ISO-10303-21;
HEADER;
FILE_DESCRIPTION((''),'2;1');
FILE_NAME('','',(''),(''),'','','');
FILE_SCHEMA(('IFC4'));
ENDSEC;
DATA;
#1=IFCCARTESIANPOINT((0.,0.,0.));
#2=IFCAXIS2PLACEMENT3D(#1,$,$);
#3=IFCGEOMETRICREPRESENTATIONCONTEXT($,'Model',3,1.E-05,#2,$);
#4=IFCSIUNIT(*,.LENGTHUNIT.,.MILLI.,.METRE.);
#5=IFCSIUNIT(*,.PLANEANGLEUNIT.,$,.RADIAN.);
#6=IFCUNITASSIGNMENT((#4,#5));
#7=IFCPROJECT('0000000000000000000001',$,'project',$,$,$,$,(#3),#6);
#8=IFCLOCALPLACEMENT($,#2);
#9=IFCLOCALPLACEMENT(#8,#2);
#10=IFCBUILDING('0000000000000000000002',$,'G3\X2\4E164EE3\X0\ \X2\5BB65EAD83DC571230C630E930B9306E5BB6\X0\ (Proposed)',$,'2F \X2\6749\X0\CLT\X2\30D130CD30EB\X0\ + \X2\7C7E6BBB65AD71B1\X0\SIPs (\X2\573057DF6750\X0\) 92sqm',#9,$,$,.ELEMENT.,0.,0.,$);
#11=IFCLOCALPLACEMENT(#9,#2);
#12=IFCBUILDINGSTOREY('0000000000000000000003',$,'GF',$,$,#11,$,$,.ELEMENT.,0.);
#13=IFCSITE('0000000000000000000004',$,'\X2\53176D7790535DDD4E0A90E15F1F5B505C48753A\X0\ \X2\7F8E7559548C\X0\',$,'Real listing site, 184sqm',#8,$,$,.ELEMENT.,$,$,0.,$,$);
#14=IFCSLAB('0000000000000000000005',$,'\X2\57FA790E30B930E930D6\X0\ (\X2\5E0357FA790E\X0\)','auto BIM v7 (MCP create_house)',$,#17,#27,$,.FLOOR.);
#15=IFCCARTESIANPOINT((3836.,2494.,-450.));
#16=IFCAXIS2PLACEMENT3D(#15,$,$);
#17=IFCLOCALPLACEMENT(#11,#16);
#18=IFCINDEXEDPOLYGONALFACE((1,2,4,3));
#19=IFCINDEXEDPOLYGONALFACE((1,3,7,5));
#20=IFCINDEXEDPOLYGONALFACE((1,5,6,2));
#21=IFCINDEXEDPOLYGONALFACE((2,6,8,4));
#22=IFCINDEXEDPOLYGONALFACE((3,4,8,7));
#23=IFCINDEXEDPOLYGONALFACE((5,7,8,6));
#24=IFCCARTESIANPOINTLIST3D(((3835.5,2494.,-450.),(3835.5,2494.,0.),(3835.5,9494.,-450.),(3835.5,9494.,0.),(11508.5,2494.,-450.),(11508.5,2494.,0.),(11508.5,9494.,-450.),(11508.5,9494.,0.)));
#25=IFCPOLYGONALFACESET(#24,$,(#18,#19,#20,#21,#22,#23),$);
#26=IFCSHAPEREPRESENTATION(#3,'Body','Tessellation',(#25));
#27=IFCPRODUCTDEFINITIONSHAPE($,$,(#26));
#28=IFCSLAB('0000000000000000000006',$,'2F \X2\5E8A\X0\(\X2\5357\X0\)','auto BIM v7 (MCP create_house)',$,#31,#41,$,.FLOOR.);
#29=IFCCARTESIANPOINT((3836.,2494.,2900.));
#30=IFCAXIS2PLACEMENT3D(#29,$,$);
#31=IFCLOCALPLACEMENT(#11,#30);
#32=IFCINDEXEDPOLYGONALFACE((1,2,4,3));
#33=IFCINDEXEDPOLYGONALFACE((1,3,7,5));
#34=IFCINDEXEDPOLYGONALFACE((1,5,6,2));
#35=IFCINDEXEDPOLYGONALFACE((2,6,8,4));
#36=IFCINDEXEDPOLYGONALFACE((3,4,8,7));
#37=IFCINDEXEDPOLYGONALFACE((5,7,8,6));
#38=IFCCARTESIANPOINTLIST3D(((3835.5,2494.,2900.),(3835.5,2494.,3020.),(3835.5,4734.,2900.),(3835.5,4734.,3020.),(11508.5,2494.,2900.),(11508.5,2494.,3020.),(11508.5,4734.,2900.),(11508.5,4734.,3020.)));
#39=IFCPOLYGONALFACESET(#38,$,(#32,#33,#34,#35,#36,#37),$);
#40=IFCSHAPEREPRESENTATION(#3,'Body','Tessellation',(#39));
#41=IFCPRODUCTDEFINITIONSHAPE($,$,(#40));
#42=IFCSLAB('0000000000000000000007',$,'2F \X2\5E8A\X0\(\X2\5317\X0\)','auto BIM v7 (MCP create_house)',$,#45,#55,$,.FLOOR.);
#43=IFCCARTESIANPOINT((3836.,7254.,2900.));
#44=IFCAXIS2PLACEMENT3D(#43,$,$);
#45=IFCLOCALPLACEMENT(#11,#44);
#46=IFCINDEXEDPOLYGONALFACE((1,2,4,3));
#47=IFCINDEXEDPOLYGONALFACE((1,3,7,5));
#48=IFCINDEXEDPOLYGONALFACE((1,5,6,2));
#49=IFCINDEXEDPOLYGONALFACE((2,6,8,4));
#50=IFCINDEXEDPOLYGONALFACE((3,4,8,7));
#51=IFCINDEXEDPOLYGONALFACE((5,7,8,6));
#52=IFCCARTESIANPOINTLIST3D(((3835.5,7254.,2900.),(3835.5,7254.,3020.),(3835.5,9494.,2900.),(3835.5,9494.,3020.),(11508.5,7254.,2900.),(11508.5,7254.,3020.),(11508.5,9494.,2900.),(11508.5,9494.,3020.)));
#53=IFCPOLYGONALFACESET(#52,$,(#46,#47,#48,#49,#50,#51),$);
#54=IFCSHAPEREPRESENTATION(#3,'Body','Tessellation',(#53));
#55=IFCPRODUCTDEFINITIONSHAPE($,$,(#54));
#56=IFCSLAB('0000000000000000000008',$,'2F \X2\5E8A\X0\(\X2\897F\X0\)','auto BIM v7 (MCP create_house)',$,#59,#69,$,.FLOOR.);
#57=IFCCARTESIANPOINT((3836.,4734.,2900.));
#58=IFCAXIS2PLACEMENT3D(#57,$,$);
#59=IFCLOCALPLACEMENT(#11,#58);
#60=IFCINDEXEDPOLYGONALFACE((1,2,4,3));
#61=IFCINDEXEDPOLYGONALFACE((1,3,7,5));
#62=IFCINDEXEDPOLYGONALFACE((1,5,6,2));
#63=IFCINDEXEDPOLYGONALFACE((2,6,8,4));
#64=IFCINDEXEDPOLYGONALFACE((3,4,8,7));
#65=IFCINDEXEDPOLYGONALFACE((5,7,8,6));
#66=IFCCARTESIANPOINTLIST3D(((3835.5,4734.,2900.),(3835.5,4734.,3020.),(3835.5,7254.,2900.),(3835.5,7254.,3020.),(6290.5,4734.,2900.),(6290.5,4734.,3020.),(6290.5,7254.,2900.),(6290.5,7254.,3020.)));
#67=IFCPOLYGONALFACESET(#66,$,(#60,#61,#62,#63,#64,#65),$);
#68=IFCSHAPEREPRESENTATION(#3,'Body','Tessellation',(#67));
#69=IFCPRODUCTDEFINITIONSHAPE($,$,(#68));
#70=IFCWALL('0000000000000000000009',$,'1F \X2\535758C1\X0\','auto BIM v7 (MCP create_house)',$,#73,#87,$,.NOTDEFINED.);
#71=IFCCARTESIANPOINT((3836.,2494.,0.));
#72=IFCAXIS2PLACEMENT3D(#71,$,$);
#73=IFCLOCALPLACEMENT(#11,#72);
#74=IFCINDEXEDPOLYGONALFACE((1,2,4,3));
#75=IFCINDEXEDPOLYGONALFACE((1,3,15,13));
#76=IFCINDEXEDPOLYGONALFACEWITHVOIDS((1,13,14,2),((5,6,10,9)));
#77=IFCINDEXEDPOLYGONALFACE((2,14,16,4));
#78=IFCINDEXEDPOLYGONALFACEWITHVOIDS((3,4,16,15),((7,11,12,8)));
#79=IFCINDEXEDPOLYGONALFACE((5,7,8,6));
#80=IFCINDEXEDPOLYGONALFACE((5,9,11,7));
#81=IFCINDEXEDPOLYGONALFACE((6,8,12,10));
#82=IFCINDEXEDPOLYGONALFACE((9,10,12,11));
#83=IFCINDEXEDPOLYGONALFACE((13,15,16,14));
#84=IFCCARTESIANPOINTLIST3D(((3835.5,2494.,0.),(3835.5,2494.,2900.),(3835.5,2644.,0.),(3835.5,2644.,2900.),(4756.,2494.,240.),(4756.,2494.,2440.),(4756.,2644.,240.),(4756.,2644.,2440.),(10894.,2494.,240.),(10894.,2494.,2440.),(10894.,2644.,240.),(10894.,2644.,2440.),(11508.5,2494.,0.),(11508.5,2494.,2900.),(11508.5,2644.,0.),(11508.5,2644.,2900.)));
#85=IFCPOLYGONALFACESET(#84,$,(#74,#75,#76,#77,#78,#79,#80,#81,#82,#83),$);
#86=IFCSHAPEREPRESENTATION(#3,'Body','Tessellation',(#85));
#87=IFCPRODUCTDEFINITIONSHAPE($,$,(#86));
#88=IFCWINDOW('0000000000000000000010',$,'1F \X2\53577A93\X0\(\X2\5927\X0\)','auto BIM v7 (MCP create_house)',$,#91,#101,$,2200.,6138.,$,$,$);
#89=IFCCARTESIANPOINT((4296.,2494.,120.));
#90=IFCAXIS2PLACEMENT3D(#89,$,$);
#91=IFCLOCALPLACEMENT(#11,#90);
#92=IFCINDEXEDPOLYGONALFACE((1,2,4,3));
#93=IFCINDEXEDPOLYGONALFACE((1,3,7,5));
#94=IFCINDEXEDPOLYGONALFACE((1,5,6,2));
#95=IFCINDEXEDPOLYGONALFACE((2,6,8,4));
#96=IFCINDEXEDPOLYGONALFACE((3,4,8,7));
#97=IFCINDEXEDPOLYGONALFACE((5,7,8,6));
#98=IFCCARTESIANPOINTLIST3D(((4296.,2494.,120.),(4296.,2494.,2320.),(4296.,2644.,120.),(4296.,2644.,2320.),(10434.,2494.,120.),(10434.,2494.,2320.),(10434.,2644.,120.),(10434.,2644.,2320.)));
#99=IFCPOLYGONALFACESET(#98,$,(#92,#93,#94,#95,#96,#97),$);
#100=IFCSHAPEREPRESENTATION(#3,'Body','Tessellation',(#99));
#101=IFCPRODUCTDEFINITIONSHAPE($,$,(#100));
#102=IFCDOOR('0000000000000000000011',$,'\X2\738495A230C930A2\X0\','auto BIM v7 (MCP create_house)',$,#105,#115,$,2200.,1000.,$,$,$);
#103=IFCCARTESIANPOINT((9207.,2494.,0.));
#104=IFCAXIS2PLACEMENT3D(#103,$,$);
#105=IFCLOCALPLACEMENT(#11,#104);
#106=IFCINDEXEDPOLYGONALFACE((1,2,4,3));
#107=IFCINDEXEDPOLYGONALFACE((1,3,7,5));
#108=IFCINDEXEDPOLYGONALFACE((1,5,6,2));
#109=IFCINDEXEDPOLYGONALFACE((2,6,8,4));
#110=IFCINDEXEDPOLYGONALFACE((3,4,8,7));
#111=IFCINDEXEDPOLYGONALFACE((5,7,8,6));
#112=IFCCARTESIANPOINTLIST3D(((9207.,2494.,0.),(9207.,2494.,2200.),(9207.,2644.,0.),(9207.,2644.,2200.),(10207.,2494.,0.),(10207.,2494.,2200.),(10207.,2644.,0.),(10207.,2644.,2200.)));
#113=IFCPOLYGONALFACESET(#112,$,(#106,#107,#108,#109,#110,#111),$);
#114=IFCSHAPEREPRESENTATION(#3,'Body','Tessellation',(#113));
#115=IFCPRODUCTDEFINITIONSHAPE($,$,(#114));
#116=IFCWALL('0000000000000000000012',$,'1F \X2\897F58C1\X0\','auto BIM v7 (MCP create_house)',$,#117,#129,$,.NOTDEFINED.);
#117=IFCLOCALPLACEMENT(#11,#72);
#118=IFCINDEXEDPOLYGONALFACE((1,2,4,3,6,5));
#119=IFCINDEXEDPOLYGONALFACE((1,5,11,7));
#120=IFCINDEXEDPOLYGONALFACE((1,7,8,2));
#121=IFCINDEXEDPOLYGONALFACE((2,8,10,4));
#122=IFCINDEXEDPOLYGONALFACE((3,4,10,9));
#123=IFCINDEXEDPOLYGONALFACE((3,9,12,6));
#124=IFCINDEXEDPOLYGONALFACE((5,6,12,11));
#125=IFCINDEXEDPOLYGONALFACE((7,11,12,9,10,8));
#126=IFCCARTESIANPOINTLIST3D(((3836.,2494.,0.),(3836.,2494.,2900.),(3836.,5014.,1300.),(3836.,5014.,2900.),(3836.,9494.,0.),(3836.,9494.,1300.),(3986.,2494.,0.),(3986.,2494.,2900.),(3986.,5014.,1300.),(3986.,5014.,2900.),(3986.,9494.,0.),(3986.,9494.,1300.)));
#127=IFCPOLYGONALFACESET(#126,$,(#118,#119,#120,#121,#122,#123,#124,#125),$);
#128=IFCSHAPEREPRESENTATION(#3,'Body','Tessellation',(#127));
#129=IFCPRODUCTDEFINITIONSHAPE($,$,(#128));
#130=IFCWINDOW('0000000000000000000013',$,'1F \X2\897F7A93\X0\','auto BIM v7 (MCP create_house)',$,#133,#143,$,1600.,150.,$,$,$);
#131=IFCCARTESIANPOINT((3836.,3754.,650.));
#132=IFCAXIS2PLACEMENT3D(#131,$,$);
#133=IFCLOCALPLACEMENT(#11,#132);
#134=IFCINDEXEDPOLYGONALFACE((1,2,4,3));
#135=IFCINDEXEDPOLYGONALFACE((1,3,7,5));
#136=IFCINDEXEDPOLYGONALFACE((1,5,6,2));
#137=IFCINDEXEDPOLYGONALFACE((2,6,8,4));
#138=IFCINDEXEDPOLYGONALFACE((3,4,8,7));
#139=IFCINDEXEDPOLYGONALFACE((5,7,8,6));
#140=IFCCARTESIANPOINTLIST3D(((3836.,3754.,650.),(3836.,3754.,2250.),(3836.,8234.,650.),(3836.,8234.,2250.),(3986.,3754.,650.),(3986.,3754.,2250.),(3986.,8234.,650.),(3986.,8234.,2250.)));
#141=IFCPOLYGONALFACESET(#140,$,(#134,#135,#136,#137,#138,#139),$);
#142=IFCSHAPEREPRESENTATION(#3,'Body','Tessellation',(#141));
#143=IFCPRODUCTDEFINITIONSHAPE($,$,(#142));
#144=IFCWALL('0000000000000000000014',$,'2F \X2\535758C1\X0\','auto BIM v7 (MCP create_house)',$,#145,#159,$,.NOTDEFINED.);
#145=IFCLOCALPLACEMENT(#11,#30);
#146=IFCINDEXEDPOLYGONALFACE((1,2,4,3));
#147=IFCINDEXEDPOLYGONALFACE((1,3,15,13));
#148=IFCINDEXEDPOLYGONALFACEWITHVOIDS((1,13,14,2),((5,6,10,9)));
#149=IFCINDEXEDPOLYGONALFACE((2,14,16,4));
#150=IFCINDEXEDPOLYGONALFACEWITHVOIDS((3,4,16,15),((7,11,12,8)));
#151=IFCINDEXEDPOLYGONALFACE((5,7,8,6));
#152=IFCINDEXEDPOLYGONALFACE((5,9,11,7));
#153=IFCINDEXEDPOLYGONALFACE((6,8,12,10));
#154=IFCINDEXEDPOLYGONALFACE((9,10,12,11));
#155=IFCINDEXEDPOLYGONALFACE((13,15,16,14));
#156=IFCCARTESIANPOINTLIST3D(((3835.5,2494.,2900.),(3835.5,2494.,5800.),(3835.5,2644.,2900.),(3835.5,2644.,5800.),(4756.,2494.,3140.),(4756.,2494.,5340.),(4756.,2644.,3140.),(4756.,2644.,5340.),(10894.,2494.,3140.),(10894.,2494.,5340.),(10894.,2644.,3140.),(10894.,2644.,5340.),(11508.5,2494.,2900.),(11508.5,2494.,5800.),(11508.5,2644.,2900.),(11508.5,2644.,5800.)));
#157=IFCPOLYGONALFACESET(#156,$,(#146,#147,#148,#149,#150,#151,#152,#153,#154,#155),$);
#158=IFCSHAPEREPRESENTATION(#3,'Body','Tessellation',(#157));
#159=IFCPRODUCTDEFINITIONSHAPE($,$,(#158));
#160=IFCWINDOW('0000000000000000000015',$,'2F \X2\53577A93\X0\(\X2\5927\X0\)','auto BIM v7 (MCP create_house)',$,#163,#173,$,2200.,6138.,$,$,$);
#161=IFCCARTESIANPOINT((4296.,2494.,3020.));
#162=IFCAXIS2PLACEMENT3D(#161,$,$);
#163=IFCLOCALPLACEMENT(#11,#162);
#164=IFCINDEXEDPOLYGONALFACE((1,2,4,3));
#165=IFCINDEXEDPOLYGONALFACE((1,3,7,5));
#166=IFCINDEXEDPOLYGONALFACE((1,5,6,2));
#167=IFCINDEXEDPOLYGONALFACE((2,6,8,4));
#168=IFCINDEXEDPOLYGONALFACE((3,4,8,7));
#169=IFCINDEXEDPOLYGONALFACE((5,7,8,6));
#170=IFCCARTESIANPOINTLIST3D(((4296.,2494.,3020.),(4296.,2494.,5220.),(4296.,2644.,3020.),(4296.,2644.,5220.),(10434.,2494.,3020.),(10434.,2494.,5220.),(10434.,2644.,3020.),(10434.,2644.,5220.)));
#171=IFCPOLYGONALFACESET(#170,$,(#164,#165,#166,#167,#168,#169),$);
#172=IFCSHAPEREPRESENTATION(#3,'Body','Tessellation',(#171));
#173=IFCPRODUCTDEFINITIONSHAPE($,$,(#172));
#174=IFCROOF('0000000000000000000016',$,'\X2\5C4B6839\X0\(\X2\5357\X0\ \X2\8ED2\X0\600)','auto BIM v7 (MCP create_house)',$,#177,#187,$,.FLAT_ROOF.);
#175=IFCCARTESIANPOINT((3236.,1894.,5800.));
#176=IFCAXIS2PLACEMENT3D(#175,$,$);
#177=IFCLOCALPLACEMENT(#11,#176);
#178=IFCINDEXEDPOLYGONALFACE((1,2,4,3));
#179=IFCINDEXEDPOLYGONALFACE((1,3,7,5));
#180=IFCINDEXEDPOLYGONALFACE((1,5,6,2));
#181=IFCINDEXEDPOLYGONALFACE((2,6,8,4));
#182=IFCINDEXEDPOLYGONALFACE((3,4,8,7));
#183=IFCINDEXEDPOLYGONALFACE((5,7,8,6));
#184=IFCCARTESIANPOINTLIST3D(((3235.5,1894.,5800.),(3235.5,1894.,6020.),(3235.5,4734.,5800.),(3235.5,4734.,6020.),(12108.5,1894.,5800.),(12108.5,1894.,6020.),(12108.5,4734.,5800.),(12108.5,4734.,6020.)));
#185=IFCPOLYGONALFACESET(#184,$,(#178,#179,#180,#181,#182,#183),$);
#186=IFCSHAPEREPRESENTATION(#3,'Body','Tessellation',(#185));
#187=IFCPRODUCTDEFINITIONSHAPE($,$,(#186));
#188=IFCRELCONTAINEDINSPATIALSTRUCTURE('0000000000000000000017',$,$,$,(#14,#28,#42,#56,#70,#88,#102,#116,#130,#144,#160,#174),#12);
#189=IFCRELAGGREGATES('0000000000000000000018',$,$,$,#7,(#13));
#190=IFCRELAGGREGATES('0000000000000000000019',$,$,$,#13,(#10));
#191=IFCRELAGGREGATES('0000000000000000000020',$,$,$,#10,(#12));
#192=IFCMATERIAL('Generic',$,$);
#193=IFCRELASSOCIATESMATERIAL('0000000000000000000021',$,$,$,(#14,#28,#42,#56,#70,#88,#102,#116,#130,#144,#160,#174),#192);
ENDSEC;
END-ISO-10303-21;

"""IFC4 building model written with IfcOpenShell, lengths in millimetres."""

from ifc_helpers import new_model, si_unit, frame, frame_2d, origin, place, context, project, spatial, rectangle, extrude, material, element, fill, save


model = new_model("IFC4")

# Units and contexts
model_context = context("Model", 3, precision=1e-05, world=origin())
ifc_project = project(units=[si_unit("LENGTHUNIT", "METRE", prefix="MILLI"), si_unit("PLANEANGLEUNIT", "RADIAN")], contexts=[model_context])

# Site, building, storey
site_placement = place(None, origin())
site = spatial("IfcSite", under=ifc_project, at=site_placement, Name="北海道川上郡弟子屈町 美留和", ObjectType="Real listing site, 184sqm", CompositionType="ELEMENT", RefElevation=0.0)
building_placement = place(site_placement, origin())
building = spatial("IfcBuilding", under=site, at=building_placement, Name="G3世代 家庭菜園テラスの家 (Proposed)", ObjectType="2F 杉CLTパネル + 籾殻断熱SIPs (地域材) 92sqm", CompositionType="ELEMENT", ElevationOfRefHeight=0.0, ElevationOfTerrain=0.0)
storey_placement = place(building_placement, origin())
storey = spatial("IfcBuildingStorey", under=building, at=storey_placement, Name="GF", CompositionType="ELEMENT", Elevation=0.0)

# Slabs
ifc_material = material(Name="Generic")
slab_1_placement = place(storey_placement, frame((3836.0, 2494.0, -450.0)))
element("IfcSlab", 1, at=slab_1_placement, inside=storey, material=ifc_material, Name="基礎スラブ (布基礎)", Description="auto BIM v7 (MCP create_house)", PredefinedType="FLOOR", context=model_context, shape_type="SweptSolid", body=[
    extrude(rectangle(XDim=7673.0, YDim=7000.0, at=frame_2d((3836.0, 3500.0))), frame((3836.0, 2494.0, -450.0)), (0.0, 0.0, 1.0), 450.0),
])
slab_2_placement = place(storey_placement, frame((3836.0, 2494.0, 2900.0)))
element("IfcSlab", 2, at=slab_2_placement, inside=storey, material=ifc_material, Name="2F 床(南)", Description="auto BIM v7 (MCP create_house)", PredefinedType="FLOOR", context=model_context, shape_type="SweptSolid", body=[
    extrude(rectangle(XDim=7673.0, YDim=2240.0, at=frame_2d((3836.0, 1120.0))), frame((3836.0, 2494.0, 2900.0)), (0.0, 0.0, 1.0), 120.0),
])
slab_3_placement = place(storey_placement, frame((3836.0, 7254.0, 2900.0)))
element("IfcSlab", 3, at=slab_3_placement, inside=storey, material=ifc_material, Name="2F 床(北)", Description="auto BIM v7 (MCP create_house)", PredefinedType="FLOOR", context=model_context, shape_type="SweptSolid", body=[
    extrude(rectangle(XDim=7673.0, YDim=2240.0, at=frame_2d((3836.0, 1120.0))), frame((3836.0, 7254.0, 2900.0)), (0.0, 0.0, 1.0), 120.0),
])
slab_4_placement = place(storey_placement, frame((3836.0, 4734.0, 2900.0)))
element("IfcSlab", 4, at=slab_4_placement, inside=storey, material=ifc_material, Name="2F 床(西)", Description="auto BIM v7 (MCP create_house)", PredefinedType="FLOOR", context=model_context, shape_type="SweptSolid", body=[
    extrude(rectangle(XDim=2455.0, YDim=2520.0, at=frame_2d((1227.0, 1260.0))), frame((3836.0, 4734.0, 2900.0)), (0.0, 0.0, 1.0), 120.0),
])

# Wall, openings, window, door
wall_1_placement = place(storey_placement, frame((3836.0, 2494.0, 0.0)))
wall_1 = element("IfcWall", 5, at=wall_1_placement, inside=storey, material=ifc_material, Name="1F 南壁", Description="auto BIM v7 (MCP create_house)", PredefinedType="NOTDEFINED", context=model_context, shape_type="SweptSolid", body=[
    extrude(rectangle(XDim=7673.0, YDim=150.0, at=frame_2d((3836.0, 75.0))), frame((3836.0, 2494.0, 0.0)), (0.0, 0.0, 1.0), 2900.0),
])
opening_1_placement = place(storey_placement, frame((4296.0, 2494.0, 120.0)))
opening_1 = element("IfcOpeningElement", 6, at=opening_1_placement, cuts=wall_1, PredefinedType="NOTDEFINED", context=model_context, shape_type="SweptSolid", body=[
    extrude(rectangle(XDim=6138.0, YDim=150.0, at=frame_2d((3069.0, 75.0))), frame((4296.0, 2494.0, 120.0)), (0.0, 0.0, 1.0), 2200.0),
])
opening_2_placement = place(storey_placement, frame((9207.0, 2494.0, 0.0)))
opening_2 = element("IfcOpeningElement", 7, at=opening_2_placement, cuts=wall_1, PredefinedType="NOTDEFINED", context=model_context, shape_type="SweptSolid", body=[
    extrude(rectangle(XDim=1000.0, YDim=150.0, at=frame_2d((500.0, 75.0))), frame((9207.0, 2494.0, 0.0)), (0.0, 0.0, 1.0), 2200.0),
])
window_1_placement = place(storey_placement, frame((4296.0, 2494.0, 120.0)))
window_1 = element("IfcWindow", 8, at=window_1_placement, inside=storey, material=ifc_material, Name="1F 南窓(大)", Description="auto BIM v7 (MCP create_house)", OverallHeight=2200.0, OverallWidth=6138.0, context=model_context, shape_type="SweptSolid", body=[
    extrude(rectangle(XDim=6138.0, YDim=150.0, at=frame_2d((3069.0, 75.0))), frame((4296.0, 2494.0, 120.0)), (0.0, 0.0, 1.0), 2200.0),
])
fill(opening_1, window_1)
door_placement = place(storey_placement, frame((9207.0, 2494.0, 0.0)))
door = element("IfcDoor", 9, at=door_placement, inside=storey, material=ifc_material, Name="玄関ドア", Description="auto BIM v7 (MCP create_house)", OverallHeight=2200.0, OverallWidth=1000.0, context=model_context, shape_type="SweptSolid", body=[
    extrude(rectangle(XDim=1000.0, YDim=150.0, at=frame_2d((500.0, 75.0))), frame((9207.0, 2494.0, 0.0)), (0.0, 0.0, 1.0), 2200.0),
])
fill(opening_2, door)

# Walls, openings, windows
wall_2_placement = place(storey_placement, frame((3836.0, 2494.0, 0.0)))
wall_2 = element("IfcWall", 10, at=wall_2_placement, inside=storey, material=ifc_material, Name="1F 西壁", Description="auto BIM v7 (MCP create_house)", PredefinedType="NOTDEFINED", context=model_context, shape_type="SweptSolid", body=[
    extrude(rectangle(XDim=150.0, YDim=7000.0, at=frame_2d((75.0, 3500.0))), frame((3836.0, 2494.0, 0.0)), (0.0, 0.0, 1.0), 2900.0),
])
opening_3_placement = place(storey_placement, frame((3836.0, 3754.0, 650.0)))
opening_3 = element("IfcOpeningElement", 11, at=opening_3_placement, cuts=wall_2, PredefinedType="NOTDEFINED", context=model_context, shape_type="SweptSolid", body=[
    extrude(rectangle(XDim=150.0, YDim=4480.0, at=frame_2d((75.0, 2240.0))), frame((3836.0, 3754.0, 650.0)), (0.0, 0.0, 1.0), 1600.0),
])
window_2_placement = place(storey_placement, frame((3836.0, 3754.0, 650.0)))
window_2 = element("IfcWindow", 12, at=window_2_placement, inside=storey, material=ifc_material, Name="1F 西窓", Description="auto BIM v7 (MCP create_house)", OverallHeight=1600.0, OverallWidth=150.0, context=model_context, shape_type="SweptSolid", body=[
    extrude(rectangle(XDim=150.0, YDim=4480.0, at=frame_2d((75.0, 2240.0))), frame((3836.0, 3754.0, 650.0)), (0.0, 0.0, 1.0), 1600.0),
])
fill(opening_3, window_2)
wall_3_placement = place(storey_placement, frame((3836.0, 2494.0, 2900.0)))
wall_3 = element("IfcWall", 13, at=wall_3_placement, inside=storey, material=ifc_material, Name="2F 南壁", Description="auto BIM v7 (MCP create_house)", PredefinedType="NOTDEFINED", context=model_context, shape_type="SweptSolid", body=[
    extrude(rectangle(XDim=7673.0, YDim=150.0, at=frame_2d((3836.0, 75.0))), frame((3836.0, 2494.0, 2900.0)), (0.0, 0.0, 1.0), 2900.0),
])
opening_4_placement = place(storey_placement, frame((4296.0, 2494.0, 3020.0)))
opening_4 = element("IfcOpeningElement", 14, at=opening_4_placement, cuts=wall_3, PredefinedType="NOTDEFINED", context=model_context, shape_type="SweptSolid", body=[
    extrude(rectangle(XDim=6138.0, YDim=150.0, at=frame_2d((3069.0, 75.0))), frame((4296.0, 2494.0, 3020.0)), (0.0, 0.0, 1.0), 2200.0),
])
window_3_placement = place(storey_placement, frame((4296.0, 2494.0, 3020.0)))
window_3 = element("IfcWindow", 15, at=window_3_placement, inside=storey, material=ifc_material, Name="2F 南窓(大)", Description="auto BIM v7 (MCP create_house)", OverallHeight=2200.0, OverallWidth=6138.0, context=model_context, shape_type="SweptSolid", body=[
    extrude(rectangle(XDim=6138.0, YDim=150.0, at=frame_2d((3069.0, 75.0))), frame((4296.0, 2494.0, 3020.0)), (0.0, 0.0, 1.0), 2200.0),
])
fill(opening_4, window_3)

# Roof
roof_1_placement = place(storey_placement, frame((3236.0, 1894.0, 5800.0)))
element("IfcRoof", 16, at=roof_1_placement, inside=storey, material=ifc_material, Name="屋根(南 軒600)", Description="auto BIM v7 (MCP create_house)", PredefinedType="FLAT_ROOF", context=model_context, shape_type="SweptSolid", body=[
    extrude(rectangle(XDim=8873.0, YDim=2840.0, at=frame_2d((4436.0, 1420.0))), frame((3236.0, 1894.0, 5800.0)), (0.0, 0.0, 1.0), 220.0),
])

save(model, "model.ifc")
